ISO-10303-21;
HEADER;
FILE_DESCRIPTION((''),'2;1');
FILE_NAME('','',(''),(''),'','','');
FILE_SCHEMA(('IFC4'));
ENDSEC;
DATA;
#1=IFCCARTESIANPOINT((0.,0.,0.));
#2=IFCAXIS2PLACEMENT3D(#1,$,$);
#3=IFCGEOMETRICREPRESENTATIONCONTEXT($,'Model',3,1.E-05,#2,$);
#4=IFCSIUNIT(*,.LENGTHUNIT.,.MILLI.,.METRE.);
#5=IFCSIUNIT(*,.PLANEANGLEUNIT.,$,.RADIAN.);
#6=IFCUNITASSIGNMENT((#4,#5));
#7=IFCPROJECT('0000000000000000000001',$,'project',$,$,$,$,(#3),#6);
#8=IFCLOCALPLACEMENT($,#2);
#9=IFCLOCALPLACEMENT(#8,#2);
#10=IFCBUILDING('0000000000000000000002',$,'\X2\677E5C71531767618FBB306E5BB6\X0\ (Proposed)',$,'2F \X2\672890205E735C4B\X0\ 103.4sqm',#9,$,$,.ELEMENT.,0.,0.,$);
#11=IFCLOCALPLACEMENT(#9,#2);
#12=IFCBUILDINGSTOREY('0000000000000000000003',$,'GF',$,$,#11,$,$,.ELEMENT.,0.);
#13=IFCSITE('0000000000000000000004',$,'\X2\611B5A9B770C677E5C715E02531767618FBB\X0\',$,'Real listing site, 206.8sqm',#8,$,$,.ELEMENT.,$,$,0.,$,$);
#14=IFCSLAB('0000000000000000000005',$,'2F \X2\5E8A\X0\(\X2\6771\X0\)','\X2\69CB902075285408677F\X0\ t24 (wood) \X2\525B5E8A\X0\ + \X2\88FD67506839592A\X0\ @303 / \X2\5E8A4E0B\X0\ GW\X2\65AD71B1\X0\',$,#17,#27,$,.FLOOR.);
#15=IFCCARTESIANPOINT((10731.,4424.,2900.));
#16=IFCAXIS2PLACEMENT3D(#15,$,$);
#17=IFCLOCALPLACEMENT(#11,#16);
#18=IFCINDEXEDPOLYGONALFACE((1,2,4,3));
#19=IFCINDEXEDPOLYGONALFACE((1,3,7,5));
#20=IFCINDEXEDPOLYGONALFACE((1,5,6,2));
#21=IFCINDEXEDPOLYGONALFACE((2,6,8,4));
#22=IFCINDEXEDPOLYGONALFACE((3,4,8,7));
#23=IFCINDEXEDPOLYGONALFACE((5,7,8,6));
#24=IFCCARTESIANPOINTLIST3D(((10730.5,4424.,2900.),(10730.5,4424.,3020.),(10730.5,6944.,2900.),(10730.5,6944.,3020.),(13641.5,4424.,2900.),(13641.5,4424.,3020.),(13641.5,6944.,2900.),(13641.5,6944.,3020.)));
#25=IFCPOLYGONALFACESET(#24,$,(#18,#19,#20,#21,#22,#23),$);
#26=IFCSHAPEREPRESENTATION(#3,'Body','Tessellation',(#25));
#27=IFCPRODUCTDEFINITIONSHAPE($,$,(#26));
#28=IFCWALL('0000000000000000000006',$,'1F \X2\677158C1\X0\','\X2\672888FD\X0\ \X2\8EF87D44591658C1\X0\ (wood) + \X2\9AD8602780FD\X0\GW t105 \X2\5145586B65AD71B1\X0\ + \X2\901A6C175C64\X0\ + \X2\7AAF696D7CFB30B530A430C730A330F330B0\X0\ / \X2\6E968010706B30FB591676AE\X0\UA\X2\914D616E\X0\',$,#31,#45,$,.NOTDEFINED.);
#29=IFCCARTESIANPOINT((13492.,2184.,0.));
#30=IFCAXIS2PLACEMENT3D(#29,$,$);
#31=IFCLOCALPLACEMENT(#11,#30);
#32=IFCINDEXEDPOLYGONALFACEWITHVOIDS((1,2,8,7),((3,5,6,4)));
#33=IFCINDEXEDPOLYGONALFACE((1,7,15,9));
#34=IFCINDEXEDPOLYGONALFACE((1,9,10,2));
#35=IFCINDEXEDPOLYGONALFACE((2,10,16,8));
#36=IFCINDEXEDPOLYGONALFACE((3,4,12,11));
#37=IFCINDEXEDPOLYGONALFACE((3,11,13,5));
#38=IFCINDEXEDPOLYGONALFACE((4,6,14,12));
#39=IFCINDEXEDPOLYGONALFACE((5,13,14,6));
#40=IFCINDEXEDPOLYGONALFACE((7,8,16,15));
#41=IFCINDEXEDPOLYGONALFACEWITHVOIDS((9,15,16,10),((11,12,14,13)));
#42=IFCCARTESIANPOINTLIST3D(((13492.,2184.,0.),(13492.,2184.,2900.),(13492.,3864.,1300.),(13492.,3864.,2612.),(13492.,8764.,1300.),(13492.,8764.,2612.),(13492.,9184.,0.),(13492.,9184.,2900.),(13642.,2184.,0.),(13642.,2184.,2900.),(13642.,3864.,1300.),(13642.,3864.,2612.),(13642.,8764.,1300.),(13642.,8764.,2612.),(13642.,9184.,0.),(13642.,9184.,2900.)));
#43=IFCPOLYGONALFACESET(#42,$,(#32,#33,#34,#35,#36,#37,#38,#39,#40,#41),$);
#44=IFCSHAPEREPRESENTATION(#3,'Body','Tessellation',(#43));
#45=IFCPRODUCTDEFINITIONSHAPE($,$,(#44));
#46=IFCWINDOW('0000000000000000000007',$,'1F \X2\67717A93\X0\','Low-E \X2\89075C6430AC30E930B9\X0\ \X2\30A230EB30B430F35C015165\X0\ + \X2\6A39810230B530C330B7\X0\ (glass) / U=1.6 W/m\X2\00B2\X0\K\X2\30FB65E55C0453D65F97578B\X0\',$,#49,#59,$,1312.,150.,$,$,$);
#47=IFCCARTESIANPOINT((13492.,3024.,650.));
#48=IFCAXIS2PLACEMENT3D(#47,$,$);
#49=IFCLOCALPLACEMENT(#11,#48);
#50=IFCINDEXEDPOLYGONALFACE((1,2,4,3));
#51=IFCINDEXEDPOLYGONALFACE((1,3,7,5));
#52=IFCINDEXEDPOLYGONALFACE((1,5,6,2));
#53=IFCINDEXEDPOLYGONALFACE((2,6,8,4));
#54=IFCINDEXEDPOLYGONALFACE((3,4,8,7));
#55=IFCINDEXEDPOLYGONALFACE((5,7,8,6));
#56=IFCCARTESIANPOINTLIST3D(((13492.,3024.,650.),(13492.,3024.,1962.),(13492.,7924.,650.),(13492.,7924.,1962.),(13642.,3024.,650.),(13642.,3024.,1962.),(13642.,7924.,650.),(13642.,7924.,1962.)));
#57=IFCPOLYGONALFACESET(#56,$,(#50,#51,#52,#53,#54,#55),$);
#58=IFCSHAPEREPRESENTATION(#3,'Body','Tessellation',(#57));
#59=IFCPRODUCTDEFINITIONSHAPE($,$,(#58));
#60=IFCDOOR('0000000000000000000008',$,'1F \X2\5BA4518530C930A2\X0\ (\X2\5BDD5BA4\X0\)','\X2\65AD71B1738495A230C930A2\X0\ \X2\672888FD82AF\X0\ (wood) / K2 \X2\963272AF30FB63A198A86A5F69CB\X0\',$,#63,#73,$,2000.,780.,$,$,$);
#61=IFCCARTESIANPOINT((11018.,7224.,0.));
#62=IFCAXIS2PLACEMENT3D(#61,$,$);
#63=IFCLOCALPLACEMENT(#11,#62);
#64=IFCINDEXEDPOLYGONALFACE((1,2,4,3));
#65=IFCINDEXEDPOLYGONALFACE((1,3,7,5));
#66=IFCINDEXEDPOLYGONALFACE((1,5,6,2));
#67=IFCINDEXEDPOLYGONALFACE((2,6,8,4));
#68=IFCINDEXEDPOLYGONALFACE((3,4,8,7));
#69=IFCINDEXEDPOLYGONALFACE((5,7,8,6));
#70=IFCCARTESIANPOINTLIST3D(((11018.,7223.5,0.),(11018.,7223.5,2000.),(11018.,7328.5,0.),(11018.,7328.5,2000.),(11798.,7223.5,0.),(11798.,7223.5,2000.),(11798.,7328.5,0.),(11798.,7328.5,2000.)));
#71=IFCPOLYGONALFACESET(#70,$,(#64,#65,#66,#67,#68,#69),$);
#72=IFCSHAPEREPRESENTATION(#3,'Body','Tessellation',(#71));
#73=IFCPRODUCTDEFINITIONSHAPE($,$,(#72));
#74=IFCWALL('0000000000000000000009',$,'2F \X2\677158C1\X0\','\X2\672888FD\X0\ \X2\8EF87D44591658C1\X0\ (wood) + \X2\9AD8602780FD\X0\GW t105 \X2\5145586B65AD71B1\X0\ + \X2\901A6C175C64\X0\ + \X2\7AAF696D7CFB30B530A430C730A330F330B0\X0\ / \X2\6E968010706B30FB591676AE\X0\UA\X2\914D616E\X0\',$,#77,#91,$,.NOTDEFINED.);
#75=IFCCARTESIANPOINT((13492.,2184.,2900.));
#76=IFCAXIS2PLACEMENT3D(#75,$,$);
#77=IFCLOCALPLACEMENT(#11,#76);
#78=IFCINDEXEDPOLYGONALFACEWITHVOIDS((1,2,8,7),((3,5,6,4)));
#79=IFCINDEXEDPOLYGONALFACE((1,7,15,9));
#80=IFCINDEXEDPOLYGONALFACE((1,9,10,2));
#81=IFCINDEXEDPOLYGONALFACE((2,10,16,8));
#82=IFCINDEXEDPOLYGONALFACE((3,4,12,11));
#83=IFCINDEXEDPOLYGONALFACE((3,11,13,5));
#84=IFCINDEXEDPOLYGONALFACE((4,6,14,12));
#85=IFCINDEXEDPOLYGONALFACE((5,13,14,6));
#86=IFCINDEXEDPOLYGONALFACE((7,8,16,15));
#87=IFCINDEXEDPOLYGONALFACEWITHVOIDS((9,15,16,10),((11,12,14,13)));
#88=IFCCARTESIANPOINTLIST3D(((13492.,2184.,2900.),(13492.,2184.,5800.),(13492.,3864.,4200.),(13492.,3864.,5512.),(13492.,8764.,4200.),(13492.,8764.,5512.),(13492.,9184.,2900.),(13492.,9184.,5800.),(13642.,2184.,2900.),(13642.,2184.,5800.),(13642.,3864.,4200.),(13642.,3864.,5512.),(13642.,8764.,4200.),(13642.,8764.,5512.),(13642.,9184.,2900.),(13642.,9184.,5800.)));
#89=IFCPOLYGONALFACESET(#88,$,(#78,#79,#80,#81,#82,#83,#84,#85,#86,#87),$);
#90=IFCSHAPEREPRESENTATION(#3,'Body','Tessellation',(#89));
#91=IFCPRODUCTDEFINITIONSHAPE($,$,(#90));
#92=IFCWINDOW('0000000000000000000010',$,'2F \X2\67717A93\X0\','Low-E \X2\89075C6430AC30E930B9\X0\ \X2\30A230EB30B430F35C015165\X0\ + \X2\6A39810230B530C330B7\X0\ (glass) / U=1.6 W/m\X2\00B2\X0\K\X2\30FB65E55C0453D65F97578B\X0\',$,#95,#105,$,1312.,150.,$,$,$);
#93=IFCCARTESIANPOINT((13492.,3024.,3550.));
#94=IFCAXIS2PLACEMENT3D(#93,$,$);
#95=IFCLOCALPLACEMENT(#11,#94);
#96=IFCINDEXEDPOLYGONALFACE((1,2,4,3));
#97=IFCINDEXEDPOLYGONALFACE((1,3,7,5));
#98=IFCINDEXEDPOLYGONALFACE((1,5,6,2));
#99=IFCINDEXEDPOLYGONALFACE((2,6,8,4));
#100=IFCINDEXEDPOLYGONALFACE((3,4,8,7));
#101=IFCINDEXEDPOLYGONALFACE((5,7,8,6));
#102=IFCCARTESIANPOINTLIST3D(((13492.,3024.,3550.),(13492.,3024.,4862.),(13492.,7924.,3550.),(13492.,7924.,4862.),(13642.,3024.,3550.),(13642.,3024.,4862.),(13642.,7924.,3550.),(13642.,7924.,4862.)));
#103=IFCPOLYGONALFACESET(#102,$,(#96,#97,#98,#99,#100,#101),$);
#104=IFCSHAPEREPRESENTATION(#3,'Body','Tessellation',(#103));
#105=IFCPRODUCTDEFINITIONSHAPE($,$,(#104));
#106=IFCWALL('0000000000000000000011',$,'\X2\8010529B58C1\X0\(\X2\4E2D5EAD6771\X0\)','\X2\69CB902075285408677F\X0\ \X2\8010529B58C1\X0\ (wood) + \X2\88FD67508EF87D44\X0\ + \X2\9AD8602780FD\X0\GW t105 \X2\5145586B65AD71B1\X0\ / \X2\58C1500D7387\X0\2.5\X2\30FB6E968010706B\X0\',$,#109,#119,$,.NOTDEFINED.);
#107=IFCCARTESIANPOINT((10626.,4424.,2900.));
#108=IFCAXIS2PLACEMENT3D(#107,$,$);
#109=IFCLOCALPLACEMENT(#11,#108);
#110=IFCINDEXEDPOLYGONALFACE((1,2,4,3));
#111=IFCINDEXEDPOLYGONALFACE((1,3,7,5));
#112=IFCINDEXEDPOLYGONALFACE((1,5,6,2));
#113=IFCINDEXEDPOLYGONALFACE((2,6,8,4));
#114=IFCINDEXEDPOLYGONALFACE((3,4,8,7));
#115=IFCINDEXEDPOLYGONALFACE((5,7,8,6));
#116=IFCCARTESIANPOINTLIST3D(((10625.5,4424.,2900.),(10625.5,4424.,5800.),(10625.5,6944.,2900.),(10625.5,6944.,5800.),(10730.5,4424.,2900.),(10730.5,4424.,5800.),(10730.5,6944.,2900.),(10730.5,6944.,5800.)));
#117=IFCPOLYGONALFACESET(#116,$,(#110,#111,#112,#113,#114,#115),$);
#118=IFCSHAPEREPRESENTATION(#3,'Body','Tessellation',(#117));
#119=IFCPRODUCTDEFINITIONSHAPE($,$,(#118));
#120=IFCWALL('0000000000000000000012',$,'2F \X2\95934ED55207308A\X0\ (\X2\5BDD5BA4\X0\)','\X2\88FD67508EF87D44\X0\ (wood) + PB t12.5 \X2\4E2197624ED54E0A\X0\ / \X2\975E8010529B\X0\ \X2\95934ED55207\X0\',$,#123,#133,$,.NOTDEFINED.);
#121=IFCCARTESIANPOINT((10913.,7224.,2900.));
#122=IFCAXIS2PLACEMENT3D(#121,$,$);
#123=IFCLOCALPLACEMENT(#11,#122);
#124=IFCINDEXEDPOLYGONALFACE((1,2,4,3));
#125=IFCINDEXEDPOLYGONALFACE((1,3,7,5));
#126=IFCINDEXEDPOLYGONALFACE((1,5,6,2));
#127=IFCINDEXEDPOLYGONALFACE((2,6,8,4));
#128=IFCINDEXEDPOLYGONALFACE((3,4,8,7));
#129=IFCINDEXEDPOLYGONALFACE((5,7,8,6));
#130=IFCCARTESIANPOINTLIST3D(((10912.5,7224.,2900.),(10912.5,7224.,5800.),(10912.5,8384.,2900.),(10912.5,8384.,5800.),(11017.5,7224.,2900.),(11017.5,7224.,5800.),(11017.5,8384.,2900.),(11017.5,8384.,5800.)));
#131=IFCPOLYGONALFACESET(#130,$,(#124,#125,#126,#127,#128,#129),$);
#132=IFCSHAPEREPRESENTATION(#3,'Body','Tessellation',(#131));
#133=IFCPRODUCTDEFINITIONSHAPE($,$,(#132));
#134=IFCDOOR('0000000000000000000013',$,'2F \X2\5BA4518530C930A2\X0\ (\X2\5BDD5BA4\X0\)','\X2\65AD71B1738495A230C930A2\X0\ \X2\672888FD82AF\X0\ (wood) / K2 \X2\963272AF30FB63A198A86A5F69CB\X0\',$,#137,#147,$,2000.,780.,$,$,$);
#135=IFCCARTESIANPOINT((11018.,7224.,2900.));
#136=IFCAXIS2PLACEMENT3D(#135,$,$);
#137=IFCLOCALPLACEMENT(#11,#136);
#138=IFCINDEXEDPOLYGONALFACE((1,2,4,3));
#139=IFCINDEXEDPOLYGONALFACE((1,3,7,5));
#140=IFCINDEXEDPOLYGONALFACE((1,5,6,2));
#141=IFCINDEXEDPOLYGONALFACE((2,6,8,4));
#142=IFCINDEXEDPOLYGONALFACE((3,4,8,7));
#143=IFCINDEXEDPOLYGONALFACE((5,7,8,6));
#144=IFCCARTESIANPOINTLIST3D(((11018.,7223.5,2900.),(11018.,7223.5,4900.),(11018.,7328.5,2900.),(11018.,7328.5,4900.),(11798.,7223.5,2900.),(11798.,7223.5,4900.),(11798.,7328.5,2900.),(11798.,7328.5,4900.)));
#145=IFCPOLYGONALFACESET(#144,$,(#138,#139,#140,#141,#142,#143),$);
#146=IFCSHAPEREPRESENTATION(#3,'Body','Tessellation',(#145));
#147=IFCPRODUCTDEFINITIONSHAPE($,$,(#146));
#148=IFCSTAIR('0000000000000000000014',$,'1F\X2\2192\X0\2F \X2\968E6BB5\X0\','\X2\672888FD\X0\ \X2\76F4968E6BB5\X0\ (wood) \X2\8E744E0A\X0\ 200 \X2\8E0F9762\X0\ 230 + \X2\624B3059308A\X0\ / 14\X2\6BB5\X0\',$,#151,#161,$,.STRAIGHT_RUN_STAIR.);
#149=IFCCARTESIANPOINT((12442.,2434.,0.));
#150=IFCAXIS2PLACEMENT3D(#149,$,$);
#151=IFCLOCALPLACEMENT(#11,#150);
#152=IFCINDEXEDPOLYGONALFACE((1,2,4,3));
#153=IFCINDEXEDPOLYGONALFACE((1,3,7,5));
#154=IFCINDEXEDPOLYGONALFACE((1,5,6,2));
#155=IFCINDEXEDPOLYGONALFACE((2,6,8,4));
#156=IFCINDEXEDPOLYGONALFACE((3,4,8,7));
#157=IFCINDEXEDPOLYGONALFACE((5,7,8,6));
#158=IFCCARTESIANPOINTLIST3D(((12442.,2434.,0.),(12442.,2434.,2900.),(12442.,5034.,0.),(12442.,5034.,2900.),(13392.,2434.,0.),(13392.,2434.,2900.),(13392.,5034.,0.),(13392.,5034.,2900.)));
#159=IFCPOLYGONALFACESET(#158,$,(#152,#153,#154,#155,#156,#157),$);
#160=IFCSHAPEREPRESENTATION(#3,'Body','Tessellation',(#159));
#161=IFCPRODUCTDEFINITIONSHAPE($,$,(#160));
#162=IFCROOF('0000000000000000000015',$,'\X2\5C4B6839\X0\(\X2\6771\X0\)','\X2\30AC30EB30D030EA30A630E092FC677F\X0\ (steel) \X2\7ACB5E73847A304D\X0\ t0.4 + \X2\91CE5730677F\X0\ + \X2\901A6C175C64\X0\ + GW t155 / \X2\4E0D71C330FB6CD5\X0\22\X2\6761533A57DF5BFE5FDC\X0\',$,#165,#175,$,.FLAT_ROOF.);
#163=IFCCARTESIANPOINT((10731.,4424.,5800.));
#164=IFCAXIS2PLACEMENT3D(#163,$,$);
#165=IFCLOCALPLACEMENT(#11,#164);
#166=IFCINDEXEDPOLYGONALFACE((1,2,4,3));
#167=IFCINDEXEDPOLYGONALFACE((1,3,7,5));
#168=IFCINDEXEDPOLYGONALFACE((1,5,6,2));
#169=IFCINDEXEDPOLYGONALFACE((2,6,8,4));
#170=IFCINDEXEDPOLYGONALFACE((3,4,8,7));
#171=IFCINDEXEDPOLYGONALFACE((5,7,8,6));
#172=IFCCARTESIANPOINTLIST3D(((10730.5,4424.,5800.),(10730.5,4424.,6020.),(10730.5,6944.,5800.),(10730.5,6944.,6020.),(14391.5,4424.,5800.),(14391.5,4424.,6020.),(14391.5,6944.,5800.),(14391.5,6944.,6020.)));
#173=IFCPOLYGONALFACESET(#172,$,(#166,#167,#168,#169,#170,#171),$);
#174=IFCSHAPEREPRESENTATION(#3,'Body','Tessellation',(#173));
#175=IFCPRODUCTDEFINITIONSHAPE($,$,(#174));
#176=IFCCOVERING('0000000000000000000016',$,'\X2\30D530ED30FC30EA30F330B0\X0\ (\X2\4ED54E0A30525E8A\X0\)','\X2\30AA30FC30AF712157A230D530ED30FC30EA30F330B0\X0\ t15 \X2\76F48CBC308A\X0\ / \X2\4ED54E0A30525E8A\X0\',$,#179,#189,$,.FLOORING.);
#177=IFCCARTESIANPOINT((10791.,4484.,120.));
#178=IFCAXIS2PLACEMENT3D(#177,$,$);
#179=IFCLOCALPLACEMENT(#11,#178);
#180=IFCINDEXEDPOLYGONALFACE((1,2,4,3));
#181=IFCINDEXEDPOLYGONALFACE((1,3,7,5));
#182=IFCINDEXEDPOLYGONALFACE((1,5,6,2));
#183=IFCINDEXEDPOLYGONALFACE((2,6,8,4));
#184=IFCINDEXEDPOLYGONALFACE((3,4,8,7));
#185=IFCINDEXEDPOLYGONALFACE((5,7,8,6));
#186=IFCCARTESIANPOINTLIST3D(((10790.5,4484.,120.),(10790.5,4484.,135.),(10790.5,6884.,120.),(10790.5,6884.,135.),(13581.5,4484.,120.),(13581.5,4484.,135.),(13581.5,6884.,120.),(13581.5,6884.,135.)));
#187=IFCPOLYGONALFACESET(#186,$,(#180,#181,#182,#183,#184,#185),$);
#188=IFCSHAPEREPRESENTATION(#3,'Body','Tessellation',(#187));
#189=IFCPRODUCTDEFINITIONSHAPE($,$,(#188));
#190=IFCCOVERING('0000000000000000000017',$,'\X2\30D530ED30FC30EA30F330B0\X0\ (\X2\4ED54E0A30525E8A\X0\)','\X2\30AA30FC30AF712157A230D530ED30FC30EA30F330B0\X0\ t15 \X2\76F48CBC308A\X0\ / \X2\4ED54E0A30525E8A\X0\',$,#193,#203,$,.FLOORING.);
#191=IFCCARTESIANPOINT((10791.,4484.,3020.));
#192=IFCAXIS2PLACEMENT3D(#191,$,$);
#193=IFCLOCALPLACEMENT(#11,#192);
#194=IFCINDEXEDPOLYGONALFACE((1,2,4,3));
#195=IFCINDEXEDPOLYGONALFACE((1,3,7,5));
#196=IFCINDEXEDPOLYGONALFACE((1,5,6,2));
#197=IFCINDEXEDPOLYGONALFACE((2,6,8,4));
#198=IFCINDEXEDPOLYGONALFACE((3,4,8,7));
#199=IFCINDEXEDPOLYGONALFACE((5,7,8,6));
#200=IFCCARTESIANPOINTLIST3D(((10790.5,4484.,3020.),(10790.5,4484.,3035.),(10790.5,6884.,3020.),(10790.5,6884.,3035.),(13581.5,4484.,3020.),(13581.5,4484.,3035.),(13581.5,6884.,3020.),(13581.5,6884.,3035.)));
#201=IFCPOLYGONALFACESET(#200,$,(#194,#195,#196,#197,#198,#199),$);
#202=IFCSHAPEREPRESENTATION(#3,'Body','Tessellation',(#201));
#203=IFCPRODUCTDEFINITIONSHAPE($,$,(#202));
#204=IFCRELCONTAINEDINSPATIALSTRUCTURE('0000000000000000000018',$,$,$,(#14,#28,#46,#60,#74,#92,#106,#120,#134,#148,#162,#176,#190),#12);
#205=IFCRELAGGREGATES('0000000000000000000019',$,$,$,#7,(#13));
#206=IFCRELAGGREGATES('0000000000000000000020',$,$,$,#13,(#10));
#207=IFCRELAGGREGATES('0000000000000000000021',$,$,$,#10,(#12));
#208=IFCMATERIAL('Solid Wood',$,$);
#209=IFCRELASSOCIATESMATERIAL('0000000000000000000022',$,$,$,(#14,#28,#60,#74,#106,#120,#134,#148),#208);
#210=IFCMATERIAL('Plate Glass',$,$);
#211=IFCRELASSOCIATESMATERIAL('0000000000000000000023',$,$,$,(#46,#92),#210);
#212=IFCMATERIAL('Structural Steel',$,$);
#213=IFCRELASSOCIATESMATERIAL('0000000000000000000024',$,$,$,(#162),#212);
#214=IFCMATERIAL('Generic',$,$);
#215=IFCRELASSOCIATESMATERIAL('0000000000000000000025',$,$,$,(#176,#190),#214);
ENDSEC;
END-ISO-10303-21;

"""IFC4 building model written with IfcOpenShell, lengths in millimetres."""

from ifc_helpers import new_model, si_unit, frame, frame_2d, origin, place, context, project, spatial, rectangle, extrude, material, element, fill, save


model = new_model("IFC4")

# Units and contexts
model_context = context("Model", 3, precision=1e-05, world=origin())
ifc_project = project(units=[si_unit("LENGTHUNIT", "METRE", prefix="MILLI"), si_unit("PLANEANGLEUNIT", "RADIAN")], contexts=[model_context])

# Site, building, storey
site_placement = place(None, origin())
site = spatial("IfcSite", under=ifc_project, at=site_placement, Name="愛媛県松山市北条辻", ObjectType="Real listing site, 206.8sqm", CompositionType="ELEMENT", RefElevation=0.0)
building_placement = place(site_placement, origin())
building = spatial("IfcBuilding", under=site, at=building_placement, Name="松山北条辻の家 (Proposed)", ObjectType="2F 木造平屋 103.4sqm", CompositionType="ELEMENT", ElevationOfRefHeight=0.0, ElevationOfTerrain=0.0)
storey_placement = place(building_placement, origin())
storey = spatial("IfcBuildingStorey", under=building, at=storey_placement, Name="GF", CompositionType="ELEMENT", Elevation=0.0)

# Slab
ifc_material_1 = material(Name="Solid Wood")
slab_1_placement = place(storey_placement, frame((10731.0, 4424.0, 2900.0)))
element("IfcSlab", 1, at=slab_1_placement, inside=storey, material=ifc_material_1, Name="2F 床(東)", Description="構造用合板 t24 (wood) 剛床 + 製材根太 @303 / 床下 GW断熱", PredefinedType="FLOOR", context=model_context, shape_type="SweptSolid", body=[
    extrude(rectangle(XDim=2911.0, YDim=2520.0, at=frame_2d((1455.0, 1260.0))), frame((10731.0, 4424.0, 2900.0)), (0.0, 0.0, 1.0), 120.0),
])

# Wall, opening, window
wall_1_placement = place(storey_placement, frame((13492.0, 2184.0, 0.0)))
wall_1 = element("IfcWall", 2, at=wall_1_placement, inside=storey, material=ifc_material_1, Name="1F 東壁", Description="木製 軸組外壁 (wood) + 高性能GW t105 充填断熱 + 通気層 + 窯業系サイディング / 準耐火・外皮UA配慮", PredefinedType="NOTDEFINED", context=model_context, shape_type="SweptSolid", body=[
    extrude(rectangle(XDim=150.0, YDim=7000.0, at=frame_2d((75.0, 3500.0))), frame((13492.0, 2184.0, 0.0)), (0.0, 0.0, 1.0), 2900.0),
])
opening_1_placement = place(storey_placement, frame((13492.0, 3024.0, 650.0)))
opening_1 = element("IfcOpeningElement", 3, at=opening_1_placement, cuts=wall_1, PredefinedType="NOTDEFINED", context=model_context, shape_type="SweptSolid", body=[
    extrude(rectangle(XDim=150.0, YDim=4900.0, at=frame_2d((75.0, 2450.0))), frame((13492.0, 3024.0, 650.0)), (0.0, 0.0, 1.0), 1312.0),
])
ifc_material_2 = material(Name="Plate Glass")
window_1_placement = place(storey_placement, frame((13492.0, 3024.0, 650.0)))
window_1 = element("IfcWindow", 4, at=window_1_placement, inside=storey, material=ifc_material_2, Name="1F 東窓", Description="Low-E 複層ガラス アルゴン封入 + 樹脂サッシ (glass) / U=1.6 W/m²K・日射取得型", OverallHeight=1312.0, OverallWidth=150.0, context=model_context, shape_type="SweptSolid", body=[
    extrude(rectangle(XDim=150.0, YDim=4900.0, at=frame_2d((75.0, 2450.0))), frame((13492.0, 3024.0, 650.0)), (0.0, 0.0, 1.0), 1312.0),
])
fill(opening_1, window_1)

# Door
door_1_placement = place(storey_placement, frame((11018.0, 7224.0, 0.0)))
element("IfcDoor", 5, at=door_1_placement, inside=storey, material=ifc_material_1, Name="1F 室内ドア (寝室)", Description="断熱玄関ドア 木製芯 (wood) / K2 防犯・採風機構", OverallHeight=2000.0, OverallWidth=780.0, context=model_context, shape_type="SweptSolid", body=[
    extrude(rectangle(XDim=780.0, YDim=105.0, at=frame_2d((390.0, 52.0))), frame((11018.0, 7224.0, 0.0)), (0.0, 0.0, 1.0), 2000.0),
])

# Wall, opening, window
wall_2_placement = place(storey_placement, frame((13492.0, 2184.0, 2900.0)))
wall_2 = element("IfcWall", 6, at=wall_2_placement, inside=storey, material=ifc_material_1, Name="2F 東壁", Description="木製 軸組外壁 (wood) + 高性能GW t105 充填断熱 + 通気層 + 窯業系サイディング / 準耐火・外皮UA配慮", PredefinedType="NOTDEFINED", context=model_context, shape_type="SweptSolid", body=[
    extrude(rectangle(XDim=150.0, YDim=7000.0, at=frame_2d((75.0, 3500.0))), frame((13492.0, 2184.0, 2900.0)), (0.0, 0.0, 1.0), 2900.0),
])
opening_2_placement = place(storey_placement, frame((13492.0, 3024.0, 3550.0)))
opening_2 = element("IfcOpeningElement", 7, at=opening_2_placement, cuts=wall_2, PredefinedType="NOTDEFINED", context=model_context, shape_type="SweptSolid", body=[
    extrude(rectangle(XDim=150.0, YDim=4900.0, at=frame_2d((75.0, 2450.0))), frame((13492.0, 3024.0, 3550.0)), (0.0, 0.0, 1.0), 1312.0),
])
window_2_placement = place(storey_placement, frame((13492.0, 3024.0, 3550.0)))
window_2 = element("IfcWindow", 8, at=window_2_placement, inside=storey, material=ifc_material_2, Name="2F 東窓", Description="Low-E 複層ガラス アルゴン封入 + 樹脂サッシ (glass) / U=1.6 W/m²K・日射取得型", OverallHeight=1312.0, OverallWidth=150.0, context=model_context, shape_type="SweptSolid", body=[
    extrude(rectangle(XDim=150.0, YDim=4900.0, at=frame_2d((75.0, 2450.0))), frame((13492.0, 3024.0, 3550.0)), (0.0, 0.0, 1.0), 1312.0),
])
fill(opening_2, window_2)

# Walls
wall_3_placement = place(storey_placement, frame((10626.0, 4424.0, 2900.0)))
element("IfcWall", 9, at=wall_3_placement, inside=storey, material=ifc_material_1, Name="耐力壁(中庭東)", Description="構造用合板 耐力壁 (wood) + 製材軸組 + 高性能GW t105 充填断熱 / 壁倍率2.5・準耐火", PredefinedType="NOTDEFINED", context=model_context, shape_type="SweptSolid", body=[
    extrude(rectangle(XDim=105.0, YDim=2520.0, at=frame_2d((52.0, 1260.0))), frame((10626.0, 4424.0, 2900.0)), (0.0, 0.0, 1.0), 2900.0),
])
wall_4_placement = place(storey_placement, frame((10913.0, 7224.0, 2900.0)))
element("IfcWall", 10, at=wall_4_placement, inside=storey, material=ifc_material_1, Name="2F 間仕切り (寝室)", Description="製材軸組 (wood) + PB t12.5 両面仕上 / 非耐力 間仕切", PredefinedType="NOTDEFINED", context=model_context, shape_type="SweptSolid", body=[
    extrude(rectangle(XDim=105.0, YDim=1160.0, at=frame_2d((52.0, 580.0))), frame((10913.0, 7224.0, 2900.0)), (0.0, 0.0, 1.0), 2900.0),
])

# Door
door_2_placement = place(storey_placement, frame((11018.0, 7224.0, 2900.0)))
element("IfcDoor", 11, at=door_2_placement, inside=storey, material=ifc_material_1, Name="2F 室内ドア (寝室)", Description="断熱玄関ドア 木製芯 (wood) / K2 防犯・採風機構", OverallHeight=2000.0, OverallWidth=780.0, context=model_context, shape_type="SweptSolid", body=[
    extrude(rectangle(XDim=780.0, YDim=105.0, at=frame_2d((390.0, 52.0))), frame((11018.0, 7224.0, 2900.0)), (0.0, 0.0, 1.0), 2000.0),
])

# Stair
stair_placement = place(storey_placement, frame((12442.0, 2434.0, 0.0)))
element("IfcStair", 12, at=stair_placement, inside=storey, material=ifc_material_1, Name="1F→2F 階段", Description="木製 直階段 (wood) 蹴上 200 踏面 230 + 手すり / 14段", PredefinedType="STRAIGHT_RUN_STAIR", context=model_context, shape_type="SweptSolid", body=[
    extrude(rectangle(XDim=950.0, YDim=2600.0, at=frame_2d((475.0, 1300.0))), frame((12442.0, 2434.0, 0.0)), (0.0, 0.0, 1.0), 2900.0),
])

# Roof
ifc_material_3 = material(Name="Structural Steel")
for number, where, name in (
    (13, (10731.0, 4424.0, 5800.0), "屋根(東)"),
):
    element("IfcRoof", number, at=place(storey_placement, frame(where)), inside=storey, material=ifc_material_3, Name=name, Description="ガルバリウム鋼板 (steel) 立平葺き t0.4 + 野地板 + 通気層 + GW t155 / 不燃・法22条区域対応", PredefinedType="FLAT_ROOF", context=model_context, shape_type="SweptSolid", body=[
        extrude(rectangle(XDim=3661.0, YDim=2520.0, at=frame_2d((1830.0, 1260.0))), frame((10731.0, 4424.0, 5800.0)), (0.0, 0.0, 1.0), 220.0),
    ])

# Coverings
ifc_material_4 = material(Name="Generic")
covering_1_placement = place(storey_placement, frame((10791.0, 4484.0, 120.0)))
element("IfcCovering", 14, at=covering_1_placement, inside=storey, material=ifc_material_4, Name="フローリング (仕上げ床)", Description="オーク無垢フローリング t15 直貼り / 仕上げ床", PredefinedType="FLOORING", context=model_context, shape_type="SweptSolid", body=[
    extrude(rectangle(XDim=2791.0, YDim=2400.0, at=frame_2d((1395.0, 1200.0))), frame((10791.0, 4484.0, 120.0)), (0.0, 0.0, 1.0), 15.0),
])
covering_2_placement = place(storey_placement, frame((10791.0, 4484.0, 3020.0)))
element("IfcCovering", 15, at=covering_2_placement, inside=storey, material=ifc_material_4, Name="フローリング (仕上げ床)", Description="オーク無垢フローリング t15 直貼り / 仕上げ床", PredefinedType="FLOORING", context=model_context, shape_type="SweptSolid", body=[
    extrude(rectangle(XDim=2791.0, YDim=2400.0, at=frame_2d((1395.0, 1200.0))), frame((10791.0, 4484.0, 3020.0)), (0.0, 0.0, 1.0), 15.0),
])

save(model, "model.ifc")
